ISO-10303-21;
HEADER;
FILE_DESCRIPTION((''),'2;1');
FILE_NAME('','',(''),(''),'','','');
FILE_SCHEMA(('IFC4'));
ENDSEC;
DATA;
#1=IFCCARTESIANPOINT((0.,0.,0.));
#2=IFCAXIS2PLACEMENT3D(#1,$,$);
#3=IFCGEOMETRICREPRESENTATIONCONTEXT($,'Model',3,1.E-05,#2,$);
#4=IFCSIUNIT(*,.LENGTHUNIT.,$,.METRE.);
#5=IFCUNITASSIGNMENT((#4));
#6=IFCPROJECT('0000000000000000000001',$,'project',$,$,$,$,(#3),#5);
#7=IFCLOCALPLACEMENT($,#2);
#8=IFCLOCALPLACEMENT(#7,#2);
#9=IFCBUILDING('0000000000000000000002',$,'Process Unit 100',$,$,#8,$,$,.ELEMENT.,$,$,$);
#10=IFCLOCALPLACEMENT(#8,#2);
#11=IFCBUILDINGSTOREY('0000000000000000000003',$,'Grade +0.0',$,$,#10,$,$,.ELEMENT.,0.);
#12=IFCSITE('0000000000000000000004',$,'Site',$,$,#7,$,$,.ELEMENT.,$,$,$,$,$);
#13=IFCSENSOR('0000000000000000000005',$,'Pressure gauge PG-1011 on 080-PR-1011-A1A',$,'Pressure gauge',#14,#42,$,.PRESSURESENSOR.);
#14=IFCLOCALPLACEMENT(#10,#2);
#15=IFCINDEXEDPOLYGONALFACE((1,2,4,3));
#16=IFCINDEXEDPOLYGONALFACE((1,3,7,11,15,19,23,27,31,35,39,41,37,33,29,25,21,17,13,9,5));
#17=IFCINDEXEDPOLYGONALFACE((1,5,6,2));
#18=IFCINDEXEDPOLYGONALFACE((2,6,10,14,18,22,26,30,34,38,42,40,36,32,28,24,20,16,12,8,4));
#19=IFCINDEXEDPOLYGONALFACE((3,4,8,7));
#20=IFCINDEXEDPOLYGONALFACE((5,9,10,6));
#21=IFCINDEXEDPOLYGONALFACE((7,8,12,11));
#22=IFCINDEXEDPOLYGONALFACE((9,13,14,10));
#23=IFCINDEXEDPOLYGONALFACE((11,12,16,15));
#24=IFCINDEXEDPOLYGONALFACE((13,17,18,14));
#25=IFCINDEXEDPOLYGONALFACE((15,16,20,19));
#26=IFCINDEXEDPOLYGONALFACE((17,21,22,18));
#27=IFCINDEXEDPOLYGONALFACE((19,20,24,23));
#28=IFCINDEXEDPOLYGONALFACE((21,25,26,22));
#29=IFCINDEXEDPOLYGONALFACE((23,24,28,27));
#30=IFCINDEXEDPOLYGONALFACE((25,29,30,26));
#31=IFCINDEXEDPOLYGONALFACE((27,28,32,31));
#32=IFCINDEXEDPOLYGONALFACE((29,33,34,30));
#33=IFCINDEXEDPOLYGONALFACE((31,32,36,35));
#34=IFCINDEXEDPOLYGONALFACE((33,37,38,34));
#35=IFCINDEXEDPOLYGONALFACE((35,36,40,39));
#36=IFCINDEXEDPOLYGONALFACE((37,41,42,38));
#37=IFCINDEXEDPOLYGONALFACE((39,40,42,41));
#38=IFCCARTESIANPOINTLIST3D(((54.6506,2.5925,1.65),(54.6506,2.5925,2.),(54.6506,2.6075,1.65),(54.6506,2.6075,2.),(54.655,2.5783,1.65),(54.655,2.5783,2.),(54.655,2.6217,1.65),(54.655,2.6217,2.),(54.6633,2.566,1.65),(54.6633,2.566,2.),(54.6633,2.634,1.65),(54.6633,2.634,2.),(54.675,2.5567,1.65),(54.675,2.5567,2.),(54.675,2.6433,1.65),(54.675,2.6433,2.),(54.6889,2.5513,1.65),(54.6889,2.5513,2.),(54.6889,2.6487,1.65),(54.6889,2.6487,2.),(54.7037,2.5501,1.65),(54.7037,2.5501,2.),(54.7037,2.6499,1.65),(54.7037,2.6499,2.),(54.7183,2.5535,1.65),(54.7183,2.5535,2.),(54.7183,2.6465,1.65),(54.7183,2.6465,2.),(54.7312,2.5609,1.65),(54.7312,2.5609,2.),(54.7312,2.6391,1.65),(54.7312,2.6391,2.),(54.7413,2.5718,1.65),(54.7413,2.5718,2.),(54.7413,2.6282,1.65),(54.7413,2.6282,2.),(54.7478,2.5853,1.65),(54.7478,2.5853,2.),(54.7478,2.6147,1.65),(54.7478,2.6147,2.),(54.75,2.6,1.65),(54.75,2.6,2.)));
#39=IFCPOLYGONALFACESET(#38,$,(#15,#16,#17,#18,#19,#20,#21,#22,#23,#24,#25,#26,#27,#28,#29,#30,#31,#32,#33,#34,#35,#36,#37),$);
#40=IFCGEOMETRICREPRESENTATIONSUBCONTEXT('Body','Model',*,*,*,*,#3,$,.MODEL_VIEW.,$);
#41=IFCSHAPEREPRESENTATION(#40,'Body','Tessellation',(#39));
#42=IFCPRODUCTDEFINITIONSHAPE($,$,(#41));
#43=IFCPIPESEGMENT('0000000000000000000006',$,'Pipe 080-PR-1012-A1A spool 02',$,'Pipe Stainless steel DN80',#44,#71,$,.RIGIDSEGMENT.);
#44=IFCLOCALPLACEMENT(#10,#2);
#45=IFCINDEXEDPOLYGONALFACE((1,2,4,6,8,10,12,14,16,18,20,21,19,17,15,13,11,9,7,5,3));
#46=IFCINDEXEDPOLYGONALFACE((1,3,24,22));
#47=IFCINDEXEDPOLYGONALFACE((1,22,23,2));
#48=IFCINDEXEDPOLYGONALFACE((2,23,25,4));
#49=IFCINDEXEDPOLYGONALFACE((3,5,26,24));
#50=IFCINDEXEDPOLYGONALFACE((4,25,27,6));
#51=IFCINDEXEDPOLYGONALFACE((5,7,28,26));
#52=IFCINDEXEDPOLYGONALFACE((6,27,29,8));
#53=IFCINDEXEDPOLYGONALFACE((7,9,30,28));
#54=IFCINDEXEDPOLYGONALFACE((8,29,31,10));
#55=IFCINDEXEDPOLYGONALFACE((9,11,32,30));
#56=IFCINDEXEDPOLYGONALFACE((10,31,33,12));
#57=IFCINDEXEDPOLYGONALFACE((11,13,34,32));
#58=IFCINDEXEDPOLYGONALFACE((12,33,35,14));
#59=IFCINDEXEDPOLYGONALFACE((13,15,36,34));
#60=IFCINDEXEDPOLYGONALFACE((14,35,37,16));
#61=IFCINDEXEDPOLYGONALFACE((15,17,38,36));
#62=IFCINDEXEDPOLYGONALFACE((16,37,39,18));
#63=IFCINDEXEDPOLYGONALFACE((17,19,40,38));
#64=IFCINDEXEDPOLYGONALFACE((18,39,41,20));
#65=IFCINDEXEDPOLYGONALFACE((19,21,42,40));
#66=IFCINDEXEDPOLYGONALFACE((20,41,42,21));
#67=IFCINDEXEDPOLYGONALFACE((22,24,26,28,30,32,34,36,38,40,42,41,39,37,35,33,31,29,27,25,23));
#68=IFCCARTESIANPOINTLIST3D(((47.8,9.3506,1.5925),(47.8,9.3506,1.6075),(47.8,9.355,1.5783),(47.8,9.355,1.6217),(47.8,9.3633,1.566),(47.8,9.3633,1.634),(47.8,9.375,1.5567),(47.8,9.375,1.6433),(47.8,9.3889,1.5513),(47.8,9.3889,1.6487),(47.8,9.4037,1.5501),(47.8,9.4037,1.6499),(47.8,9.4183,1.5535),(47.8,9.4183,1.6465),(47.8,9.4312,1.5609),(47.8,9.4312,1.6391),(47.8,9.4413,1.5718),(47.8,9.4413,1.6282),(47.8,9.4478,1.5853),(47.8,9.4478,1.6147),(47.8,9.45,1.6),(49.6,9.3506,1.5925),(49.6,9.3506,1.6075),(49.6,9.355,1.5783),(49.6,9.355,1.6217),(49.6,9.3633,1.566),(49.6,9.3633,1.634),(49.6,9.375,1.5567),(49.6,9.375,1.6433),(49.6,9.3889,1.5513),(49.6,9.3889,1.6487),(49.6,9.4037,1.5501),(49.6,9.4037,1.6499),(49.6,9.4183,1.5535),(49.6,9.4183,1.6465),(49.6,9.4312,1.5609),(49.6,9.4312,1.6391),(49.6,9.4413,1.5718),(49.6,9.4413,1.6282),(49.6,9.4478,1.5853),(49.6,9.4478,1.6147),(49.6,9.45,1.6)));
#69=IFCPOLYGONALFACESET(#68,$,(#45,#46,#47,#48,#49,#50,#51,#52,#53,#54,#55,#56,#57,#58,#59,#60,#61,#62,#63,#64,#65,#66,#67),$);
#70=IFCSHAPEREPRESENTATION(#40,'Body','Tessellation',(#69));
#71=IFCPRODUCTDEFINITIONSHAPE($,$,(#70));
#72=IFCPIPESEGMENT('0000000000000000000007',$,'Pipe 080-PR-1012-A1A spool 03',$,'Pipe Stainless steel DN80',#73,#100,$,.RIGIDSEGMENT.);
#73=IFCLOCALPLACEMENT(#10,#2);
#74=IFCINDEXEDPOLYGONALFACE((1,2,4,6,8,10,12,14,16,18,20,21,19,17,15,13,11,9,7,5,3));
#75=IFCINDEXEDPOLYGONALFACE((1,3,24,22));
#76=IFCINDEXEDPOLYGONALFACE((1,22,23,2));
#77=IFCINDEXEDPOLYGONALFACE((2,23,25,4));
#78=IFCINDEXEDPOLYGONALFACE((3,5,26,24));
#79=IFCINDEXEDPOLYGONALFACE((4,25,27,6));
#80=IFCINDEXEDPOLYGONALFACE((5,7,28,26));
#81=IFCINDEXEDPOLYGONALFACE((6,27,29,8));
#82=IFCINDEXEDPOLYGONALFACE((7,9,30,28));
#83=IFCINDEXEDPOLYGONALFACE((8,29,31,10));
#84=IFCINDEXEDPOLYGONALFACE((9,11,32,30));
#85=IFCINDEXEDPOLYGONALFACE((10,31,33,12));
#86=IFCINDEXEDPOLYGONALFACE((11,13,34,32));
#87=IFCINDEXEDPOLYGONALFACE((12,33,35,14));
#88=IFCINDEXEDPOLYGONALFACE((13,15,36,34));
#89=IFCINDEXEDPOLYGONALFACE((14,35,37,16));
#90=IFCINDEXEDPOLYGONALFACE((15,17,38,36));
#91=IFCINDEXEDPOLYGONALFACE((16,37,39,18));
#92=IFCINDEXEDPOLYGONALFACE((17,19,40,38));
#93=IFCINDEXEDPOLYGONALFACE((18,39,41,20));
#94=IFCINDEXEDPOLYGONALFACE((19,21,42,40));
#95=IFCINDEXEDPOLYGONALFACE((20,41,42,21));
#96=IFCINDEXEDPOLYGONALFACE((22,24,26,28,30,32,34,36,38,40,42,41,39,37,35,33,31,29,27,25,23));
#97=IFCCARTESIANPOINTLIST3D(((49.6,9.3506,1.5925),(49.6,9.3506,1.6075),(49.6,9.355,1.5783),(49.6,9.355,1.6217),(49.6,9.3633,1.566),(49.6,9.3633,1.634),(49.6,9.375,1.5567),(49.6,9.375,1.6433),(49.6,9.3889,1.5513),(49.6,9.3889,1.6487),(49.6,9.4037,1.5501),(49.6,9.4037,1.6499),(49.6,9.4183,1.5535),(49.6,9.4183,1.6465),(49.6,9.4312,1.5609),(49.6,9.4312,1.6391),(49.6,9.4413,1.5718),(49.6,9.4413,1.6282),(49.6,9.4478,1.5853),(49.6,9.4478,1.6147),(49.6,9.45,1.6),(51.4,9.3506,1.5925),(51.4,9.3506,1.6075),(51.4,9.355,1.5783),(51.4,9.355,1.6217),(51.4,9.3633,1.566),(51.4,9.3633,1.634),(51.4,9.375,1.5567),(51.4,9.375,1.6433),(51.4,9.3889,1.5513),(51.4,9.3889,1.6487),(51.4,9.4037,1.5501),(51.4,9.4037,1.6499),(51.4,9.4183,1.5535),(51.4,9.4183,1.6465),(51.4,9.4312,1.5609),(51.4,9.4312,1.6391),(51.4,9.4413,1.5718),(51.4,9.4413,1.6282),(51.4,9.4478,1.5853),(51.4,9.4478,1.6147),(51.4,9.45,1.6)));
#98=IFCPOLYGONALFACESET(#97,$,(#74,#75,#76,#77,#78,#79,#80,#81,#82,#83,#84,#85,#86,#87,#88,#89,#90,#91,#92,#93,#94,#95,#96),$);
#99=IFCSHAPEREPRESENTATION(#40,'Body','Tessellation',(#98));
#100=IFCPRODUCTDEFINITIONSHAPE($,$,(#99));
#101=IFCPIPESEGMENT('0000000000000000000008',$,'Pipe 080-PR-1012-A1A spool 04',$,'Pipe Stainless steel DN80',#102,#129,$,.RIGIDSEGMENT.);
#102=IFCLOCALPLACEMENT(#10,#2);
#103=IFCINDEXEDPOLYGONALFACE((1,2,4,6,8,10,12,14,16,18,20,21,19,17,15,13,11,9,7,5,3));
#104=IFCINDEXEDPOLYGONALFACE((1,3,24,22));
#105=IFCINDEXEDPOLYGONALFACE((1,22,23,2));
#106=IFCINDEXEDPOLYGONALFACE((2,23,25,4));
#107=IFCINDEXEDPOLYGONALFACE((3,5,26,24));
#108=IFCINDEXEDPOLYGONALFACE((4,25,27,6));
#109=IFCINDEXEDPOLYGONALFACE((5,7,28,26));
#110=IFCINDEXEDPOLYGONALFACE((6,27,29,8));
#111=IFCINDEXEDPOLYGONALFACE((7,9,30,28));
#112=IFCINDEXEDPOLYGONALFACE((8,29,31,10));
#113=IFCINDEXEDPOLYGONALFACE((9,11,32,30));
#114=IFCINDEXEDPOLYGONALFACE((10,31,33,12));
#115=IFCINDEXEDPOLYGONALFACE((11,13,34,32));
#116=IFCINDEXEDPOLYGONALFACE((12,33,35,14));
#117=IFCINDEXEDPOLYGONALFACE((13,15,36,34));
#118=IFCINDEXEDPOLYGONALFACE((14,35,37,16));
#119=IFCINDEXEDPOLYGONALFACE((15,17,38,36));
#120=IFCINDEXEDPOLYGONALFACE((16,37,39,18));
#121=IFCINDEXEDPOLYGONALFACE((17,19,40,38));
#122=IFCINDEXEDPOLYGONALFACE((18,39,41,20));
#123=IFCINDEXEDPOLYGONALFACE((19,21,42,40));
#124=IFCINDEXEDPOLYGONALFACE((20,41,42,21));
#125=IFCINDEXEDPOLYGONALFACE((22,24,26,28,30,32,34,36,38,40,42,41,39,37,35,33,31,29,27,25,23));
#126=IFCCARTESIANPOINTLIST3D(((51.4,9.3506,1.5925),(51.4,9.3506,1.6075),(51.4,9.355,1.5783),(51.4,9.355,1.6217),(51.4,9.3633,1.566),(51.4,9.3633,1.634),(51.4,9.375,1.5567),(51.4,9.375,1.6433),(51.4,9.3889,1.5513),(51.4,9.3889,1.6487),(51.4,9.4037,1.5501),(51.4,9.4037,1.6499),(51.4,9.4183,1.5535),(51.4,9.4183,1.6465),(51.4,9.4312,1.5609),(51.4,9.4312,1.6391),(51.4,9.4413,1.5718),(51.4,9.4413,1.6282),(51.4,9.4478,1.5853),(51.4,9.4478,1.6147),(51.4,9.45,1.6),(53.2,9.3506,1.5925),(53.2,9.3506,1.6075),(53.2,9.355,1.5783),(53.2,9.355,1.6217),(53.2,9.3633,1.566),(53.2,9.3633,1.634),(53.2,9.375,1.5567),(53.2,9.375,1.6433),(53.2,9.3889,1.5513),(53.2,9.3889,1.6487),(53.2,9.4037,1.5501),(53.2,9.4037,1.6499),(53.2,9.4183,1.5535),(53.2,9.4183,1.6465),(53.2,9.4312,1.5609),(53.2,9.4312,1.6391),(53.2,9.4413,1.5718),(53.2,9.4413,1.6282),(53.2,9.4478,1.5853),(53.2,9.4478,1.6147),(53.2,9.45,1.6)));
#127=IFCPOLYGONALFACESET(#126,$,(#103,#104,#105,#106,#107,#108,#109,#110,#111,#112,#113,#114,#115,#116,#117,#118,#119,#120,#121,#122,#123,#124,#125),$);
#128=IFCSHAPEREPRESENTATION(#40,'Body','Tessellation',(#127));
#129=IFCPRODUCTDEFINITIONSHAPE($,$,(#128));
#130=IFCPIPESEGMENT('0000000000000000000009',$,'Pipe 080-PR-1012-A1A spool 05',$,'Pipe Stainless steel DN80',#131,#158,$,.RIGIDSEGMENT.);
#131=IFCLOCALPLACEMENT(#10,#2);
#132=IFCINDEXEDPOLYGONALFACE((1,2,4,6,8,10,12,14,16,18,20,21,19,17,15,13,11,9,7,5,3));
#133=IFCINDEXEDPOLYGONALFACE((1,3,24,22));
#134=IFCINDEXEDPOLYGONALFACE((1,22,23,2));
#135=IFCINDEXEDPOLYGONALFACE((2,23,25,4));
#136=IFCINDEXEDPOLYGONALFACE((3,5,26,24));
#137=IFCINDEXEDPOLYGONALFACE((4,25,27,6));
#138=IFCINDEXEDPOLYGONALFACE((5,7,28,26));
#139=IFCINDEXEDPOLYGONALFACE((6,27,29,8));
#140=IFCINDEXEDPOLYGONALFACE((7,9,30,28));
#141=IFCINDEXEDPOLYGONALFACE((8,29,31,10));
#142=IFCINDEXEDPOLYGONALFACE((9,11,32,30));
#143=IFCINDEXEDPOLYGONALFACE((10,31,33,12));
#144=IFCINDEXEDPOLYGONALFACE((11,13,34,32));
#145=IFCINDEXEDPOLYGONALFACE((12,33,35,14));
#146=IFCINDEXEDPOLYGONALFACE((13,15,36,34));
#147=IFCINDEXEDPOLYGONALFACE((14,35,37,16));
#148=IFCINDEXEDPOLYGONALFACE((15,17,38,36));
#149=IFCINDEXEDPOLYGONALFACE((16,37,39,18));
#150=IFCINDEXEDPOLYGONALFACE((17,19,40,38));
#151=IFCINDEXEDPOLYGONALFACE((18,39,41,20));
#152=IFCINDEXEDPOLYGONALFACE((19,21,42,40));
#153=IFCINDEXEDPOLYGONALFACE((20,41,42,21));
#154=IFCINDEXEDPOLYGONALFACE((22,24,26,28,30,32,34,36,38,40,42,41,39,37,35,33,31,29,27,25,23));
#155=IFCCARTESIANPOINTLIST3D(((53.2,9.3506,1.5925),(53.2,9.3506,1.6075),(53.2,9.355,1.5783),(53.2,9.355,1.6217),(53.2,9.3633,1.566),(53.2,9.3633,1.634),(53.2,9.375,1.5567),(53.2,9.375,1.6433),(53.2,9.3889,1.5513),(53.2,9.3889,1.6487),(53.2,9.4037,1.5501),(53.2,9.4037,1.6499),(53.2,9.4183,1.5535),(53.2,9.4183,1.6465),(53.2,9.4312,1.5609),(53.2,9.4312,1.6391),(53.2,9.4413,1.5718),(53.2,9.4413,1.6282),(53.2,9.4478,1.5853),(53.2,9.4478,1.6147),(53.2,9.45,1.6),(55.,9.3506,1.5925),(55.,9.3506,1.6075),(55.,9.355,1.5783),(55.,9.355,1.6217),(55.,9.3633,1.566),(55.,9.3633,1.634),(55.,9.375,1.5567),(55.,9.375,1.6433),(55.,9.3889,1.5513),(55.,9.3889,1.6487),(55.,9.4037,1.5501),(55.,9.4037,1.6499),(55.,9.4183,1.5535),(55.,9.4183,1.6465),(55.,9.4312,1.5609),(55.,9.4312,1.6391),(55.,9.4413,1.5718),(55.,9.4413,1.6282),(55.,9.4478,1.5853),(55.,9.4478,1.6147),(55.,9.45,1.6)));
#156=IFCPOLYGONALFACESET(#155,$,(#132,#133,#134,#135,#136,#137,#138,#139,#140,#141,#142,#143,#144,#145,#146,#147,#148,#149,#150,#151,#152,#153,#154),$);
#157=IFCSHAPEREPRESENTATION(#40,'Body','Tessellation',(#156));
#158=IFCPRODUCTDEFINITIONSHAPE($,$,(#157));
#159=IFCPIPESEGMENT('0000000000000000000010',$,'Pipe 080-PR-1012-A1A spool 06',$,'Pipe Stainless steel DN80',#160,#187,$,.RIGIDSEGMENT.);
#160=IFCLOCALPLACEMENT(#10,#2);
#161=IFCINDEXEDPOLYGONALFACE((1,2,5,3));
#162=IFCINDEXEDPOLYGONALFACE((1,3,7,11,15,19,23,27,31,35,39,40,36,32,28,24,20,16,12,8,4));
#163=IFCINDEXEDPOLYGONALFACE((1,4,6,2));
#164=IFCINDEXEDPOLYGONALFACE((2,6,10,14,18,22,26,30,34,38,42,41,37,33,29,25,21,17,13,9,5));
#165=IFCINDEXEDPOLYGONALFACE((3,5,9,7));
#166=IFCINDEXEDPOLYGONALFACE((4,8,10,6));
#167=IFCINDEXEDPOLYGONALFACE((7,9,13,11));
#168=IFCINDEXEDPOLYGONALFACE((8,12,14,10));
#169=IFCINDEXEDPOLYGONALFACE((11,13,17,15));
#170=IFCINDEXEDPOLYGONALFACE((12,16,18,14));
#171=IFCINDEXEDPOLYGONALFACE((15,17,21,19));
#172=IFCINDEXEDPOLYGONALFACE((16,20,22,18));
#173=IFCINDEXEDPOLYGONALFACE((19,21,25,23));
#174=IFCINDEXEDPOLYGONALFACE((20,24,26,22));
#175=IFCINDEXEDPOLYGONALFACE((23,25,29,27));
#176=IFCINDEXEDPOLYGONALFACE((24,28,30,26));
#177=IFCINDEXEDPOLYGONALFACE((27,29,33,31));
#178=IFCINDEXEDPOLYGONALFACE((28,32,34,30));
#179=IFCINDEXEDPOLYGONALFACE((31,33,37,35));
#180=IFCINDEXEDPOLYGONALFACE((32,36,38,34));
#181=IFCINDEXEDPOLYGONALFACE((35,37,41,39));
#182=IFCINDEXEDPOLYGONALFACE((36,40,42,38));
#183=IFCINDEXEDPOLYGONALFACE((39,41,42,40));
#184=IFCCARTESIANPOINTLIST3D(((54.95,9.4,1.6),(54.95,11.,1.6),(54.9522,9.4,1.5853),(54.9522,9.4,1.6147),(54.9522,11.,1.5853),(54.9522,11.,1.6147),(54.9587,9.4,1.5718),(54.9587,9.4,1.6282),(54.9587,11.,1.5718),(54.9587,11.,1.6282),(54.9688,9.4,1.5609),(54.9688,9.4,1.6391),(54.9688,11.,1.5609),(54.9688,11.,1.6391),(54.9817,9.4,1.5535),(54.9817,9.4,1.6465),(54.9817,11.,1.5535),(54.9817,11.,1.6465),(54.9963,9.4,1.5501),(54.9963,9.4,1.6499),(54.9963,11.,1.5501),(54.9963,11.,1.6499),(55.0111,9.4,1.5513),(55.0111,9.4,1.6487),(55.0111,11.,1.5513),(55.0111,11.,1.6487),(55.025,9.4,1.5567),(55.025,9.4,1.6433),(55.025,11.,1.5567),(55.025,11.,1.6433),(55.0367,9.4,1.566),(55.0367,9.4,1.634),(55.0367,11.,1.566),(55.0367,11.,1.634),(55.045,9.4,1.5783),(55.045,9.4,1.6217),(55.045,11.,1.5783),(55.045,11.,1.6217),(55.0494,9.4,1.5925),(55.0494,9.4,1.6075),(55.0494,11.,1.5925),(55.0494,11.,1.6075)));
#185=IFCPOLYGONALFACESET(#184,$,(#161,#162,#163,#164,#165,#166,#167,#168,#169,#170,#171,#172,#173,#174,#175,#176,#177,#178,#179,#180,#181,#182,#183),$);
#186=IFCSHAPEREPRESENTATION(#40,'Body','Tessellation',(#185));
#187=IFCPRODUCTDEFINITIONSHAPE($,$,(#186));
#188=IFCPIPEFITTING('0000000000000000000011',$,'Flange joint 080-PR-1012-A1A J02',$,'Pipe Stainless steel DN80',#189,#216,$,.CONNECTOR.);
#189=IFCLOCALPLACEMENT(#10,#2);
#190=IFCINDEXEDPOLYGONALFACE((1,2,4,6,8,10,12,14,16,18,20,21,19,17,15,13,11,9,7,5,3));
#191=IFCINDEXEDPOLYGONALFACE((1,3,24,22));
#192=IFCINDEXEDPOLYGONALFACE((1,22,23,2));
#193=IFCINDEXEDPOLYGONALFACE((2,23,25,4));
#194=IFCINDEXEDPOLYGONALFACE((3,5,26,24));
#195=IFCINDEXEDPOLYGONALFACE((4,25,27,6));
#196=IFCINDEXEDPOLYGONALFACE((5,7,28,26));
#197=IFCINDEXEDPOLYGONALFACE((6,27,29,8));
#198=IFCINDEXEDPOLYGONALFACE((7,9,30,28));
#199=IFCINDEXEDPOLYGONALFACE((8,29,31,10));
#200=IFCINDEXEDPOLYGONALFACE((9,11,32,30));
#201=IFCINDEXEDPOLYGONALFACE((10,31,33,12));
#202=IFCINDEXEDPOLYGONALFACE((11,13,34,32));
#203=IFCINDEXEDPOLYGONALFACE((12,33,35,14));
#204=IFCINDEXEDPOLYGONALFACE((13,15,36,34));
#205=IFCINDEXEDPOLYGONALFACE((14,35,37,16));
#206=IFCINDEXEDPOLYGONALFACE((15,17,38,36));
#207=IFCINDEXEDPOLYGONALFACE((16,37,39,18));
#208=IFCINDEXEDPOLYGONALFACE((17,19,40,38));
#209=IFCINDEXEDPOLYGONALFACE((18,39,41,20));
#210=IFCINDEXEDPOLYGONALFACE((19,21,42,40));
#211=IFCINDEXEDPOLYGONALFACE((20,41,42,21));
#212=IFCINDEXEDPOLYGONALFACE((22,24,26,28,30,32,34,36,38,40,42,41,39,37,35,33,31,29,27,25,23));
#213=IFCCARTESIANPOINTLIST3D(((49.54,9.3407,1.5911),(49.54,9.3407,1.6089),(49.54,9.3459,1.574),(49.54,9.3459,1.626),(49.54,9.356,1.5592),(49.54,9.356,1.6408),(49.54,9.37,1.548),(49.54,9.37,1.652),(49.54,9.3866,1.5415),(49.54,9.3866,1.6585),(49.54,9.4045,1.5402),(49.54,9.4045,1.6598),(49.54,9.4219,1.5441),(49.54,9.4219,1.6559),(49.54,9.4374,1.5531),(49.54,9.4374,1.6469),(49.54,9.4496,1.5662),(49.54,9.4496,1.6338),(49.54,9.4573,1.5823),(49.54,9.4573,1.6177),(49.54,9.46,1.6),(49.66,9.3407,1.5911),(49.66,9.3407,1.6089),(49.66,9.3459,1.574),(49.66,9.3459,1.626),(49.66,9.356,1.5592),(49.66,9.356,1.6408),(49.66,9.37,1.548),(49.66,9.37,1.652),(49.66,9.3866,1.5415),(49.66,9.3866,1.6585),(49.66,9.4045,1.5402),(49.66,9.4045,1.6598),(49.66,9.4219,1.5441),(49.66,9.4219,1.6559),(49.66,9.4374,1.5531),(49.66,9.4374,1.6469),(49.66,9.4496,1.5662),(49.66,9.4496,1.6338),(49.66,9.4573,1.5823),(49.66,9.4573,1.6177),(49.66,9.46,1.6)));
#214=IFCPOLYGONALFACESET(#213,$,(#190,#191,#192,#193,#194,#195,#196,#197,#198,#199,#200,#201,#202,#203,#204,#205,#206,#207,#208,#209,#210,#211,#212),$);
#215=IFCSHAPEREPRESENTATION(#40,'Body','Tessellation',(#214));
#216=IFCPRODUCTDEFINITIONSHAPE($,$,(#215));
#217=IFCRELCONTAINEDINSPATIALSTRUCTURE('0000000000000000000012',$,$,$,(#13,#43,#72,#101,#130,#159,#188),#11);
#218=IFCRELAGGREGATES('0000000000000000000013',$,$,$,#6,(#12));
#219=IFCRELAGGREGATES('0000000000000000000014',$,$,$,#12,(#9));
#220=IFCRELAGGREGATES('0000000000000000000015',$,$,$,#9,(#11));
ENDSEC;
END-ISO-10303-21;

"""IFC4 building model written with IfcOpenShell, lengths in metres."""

from ifc_helpers import new_model, si_unit, frame, origin, place, context, subcontext, project, spatial, circle, extrude, element, save


model = new_model("IFC4")

# Units and contexts
model_context = context("Model", 3, precision=1e-05, world=origin())
body_context = subcontext(model_context, "Body", "Model", "MODEL_VIEW")
ifc_project = project(units=[si_unit("LENGTHUNIT", "METRE")], contexts=[model_context])

# Site, building, storey
site_placement = place(None, origin())
site = spatial("IfcSite", under=ifc_project, at=site_placement, Name="Site", CompositionType="ELEMENT")
building_placement = place(site_placement, origin())
building = spatial("IfcBuilding", under=site, at=building_placement, Name="Process Unit 100", CompositionType="ELEMENT")
storey_placement = place(building_placement, origin())
storey = spatial("IfcBuildingStorey", under=building, at=storey_placement, Name="Grade +0.0", CompositionType="ELEMENT", Elevation=0.0)

# Sensor
sensor_placement = place(storey_placement, frame((54.7, 2.6, 1.65), z_axis=(0.0, 0.0, 1.0), x_axis=(1.0, 0.0, 0.0)))
element("IfcSensor", 1, at=sensor_placement, inside=storey, Name="Pressure gauge PG-1011 on 080-PR-1011-A1A", ObjectType="Pressure gauge", PredefinedType="PRESSURESENSOR", context=body_context, shape_type="SweptSolid", body=[
    extrude(circle(Radius=0.05), origin(), (0.0, 0.0, 1.0), 0.35),
])

# Pipe segments
for number, where, z_axis, x_axis, name in (
    (2, (47.8, 9.4, 1.6), (1.0, 0.0, 0.0), (0.0, 1.0, 0.0), "Pipe 080-PR-1012-A1A spool 02"),
    (3, (49.6, 9.4, 1.6), (1.0, 0.0, 0.0), (0.0, 1.0, 0.0), "Pipe 080-PR-1012-A1A spool 03"),
    (4, (51.4, 9.4, 1.6), (1.0, 0.0, 0.0), (0.0, 1.0, 0.0), "Pipe 080-PR-1012-A1A spool 04"),
    (5, (53.2, 9.4, 1.6), (1.0, 0.0, 0.0), (0.0, 1.0, 0.0), "Pipe 080-PR-1012-A1A spool 05"),
):
    element("IfcPipeSegment", number, at=place(storey_placement, frame(where, z_axis=z_axis, x_axis=x_axis)), inside=storey, Name=name, ObjectType="Pipe Stainless steel DN80", PredefinedType="RIGIDSEGMENT", context=body_context, shape_type="SweptSolid", body=[
        extrude(circle(Radius=0.05), origin(), (0.0, 0.0, 1.0), 1.8),
    ])
pipe_segment_placement = place(storey_placement, frame((55.0, 9.4, 1.6), z_axis=(0.0, 1.0, 0.0), x_axis=(-1.0, 0.0, 0.0)))
element("IfcPipeSegment", 6, at=pipe_segment_placement, inside=storey, Name="Pipe 080-PR-1012-A1A spool 06", ObjectType="Pipe Stainless steel DN80", PredefinedType="RIGIDSEGMENT", context=body_context, shape_type="SweptSolid", body=[
    extrude(circle(Radius=0.05), origin(), (0.0, 0.0, 1.0), 1.6),
])

# Pipe fitting
for number, where, z_axis, x_axis, name in (
    (7, (49.54, 9.4, 1.6), (1.0, 0.0, 0.0), (0.0, 1.0, 0.0), "Flange joint 080-PR-1012-A1A J02"),
):
    element("IfcPipeFitting", number, at=place(storey_placement, frame(where, z_axis=z_axis, x_axis=x_axis)), inside=storey, Name=name, ObjectType="Pipe Stainless steel DN80", PredefinedType="CONNECTOR", context=body_context, shape_type="SweptSolid", body=[
        extrude(circle(Radius=0.06), origin(), (0.0, 0.0, 1.0), 0.12),
    ])

save(model, "model.ifc")
